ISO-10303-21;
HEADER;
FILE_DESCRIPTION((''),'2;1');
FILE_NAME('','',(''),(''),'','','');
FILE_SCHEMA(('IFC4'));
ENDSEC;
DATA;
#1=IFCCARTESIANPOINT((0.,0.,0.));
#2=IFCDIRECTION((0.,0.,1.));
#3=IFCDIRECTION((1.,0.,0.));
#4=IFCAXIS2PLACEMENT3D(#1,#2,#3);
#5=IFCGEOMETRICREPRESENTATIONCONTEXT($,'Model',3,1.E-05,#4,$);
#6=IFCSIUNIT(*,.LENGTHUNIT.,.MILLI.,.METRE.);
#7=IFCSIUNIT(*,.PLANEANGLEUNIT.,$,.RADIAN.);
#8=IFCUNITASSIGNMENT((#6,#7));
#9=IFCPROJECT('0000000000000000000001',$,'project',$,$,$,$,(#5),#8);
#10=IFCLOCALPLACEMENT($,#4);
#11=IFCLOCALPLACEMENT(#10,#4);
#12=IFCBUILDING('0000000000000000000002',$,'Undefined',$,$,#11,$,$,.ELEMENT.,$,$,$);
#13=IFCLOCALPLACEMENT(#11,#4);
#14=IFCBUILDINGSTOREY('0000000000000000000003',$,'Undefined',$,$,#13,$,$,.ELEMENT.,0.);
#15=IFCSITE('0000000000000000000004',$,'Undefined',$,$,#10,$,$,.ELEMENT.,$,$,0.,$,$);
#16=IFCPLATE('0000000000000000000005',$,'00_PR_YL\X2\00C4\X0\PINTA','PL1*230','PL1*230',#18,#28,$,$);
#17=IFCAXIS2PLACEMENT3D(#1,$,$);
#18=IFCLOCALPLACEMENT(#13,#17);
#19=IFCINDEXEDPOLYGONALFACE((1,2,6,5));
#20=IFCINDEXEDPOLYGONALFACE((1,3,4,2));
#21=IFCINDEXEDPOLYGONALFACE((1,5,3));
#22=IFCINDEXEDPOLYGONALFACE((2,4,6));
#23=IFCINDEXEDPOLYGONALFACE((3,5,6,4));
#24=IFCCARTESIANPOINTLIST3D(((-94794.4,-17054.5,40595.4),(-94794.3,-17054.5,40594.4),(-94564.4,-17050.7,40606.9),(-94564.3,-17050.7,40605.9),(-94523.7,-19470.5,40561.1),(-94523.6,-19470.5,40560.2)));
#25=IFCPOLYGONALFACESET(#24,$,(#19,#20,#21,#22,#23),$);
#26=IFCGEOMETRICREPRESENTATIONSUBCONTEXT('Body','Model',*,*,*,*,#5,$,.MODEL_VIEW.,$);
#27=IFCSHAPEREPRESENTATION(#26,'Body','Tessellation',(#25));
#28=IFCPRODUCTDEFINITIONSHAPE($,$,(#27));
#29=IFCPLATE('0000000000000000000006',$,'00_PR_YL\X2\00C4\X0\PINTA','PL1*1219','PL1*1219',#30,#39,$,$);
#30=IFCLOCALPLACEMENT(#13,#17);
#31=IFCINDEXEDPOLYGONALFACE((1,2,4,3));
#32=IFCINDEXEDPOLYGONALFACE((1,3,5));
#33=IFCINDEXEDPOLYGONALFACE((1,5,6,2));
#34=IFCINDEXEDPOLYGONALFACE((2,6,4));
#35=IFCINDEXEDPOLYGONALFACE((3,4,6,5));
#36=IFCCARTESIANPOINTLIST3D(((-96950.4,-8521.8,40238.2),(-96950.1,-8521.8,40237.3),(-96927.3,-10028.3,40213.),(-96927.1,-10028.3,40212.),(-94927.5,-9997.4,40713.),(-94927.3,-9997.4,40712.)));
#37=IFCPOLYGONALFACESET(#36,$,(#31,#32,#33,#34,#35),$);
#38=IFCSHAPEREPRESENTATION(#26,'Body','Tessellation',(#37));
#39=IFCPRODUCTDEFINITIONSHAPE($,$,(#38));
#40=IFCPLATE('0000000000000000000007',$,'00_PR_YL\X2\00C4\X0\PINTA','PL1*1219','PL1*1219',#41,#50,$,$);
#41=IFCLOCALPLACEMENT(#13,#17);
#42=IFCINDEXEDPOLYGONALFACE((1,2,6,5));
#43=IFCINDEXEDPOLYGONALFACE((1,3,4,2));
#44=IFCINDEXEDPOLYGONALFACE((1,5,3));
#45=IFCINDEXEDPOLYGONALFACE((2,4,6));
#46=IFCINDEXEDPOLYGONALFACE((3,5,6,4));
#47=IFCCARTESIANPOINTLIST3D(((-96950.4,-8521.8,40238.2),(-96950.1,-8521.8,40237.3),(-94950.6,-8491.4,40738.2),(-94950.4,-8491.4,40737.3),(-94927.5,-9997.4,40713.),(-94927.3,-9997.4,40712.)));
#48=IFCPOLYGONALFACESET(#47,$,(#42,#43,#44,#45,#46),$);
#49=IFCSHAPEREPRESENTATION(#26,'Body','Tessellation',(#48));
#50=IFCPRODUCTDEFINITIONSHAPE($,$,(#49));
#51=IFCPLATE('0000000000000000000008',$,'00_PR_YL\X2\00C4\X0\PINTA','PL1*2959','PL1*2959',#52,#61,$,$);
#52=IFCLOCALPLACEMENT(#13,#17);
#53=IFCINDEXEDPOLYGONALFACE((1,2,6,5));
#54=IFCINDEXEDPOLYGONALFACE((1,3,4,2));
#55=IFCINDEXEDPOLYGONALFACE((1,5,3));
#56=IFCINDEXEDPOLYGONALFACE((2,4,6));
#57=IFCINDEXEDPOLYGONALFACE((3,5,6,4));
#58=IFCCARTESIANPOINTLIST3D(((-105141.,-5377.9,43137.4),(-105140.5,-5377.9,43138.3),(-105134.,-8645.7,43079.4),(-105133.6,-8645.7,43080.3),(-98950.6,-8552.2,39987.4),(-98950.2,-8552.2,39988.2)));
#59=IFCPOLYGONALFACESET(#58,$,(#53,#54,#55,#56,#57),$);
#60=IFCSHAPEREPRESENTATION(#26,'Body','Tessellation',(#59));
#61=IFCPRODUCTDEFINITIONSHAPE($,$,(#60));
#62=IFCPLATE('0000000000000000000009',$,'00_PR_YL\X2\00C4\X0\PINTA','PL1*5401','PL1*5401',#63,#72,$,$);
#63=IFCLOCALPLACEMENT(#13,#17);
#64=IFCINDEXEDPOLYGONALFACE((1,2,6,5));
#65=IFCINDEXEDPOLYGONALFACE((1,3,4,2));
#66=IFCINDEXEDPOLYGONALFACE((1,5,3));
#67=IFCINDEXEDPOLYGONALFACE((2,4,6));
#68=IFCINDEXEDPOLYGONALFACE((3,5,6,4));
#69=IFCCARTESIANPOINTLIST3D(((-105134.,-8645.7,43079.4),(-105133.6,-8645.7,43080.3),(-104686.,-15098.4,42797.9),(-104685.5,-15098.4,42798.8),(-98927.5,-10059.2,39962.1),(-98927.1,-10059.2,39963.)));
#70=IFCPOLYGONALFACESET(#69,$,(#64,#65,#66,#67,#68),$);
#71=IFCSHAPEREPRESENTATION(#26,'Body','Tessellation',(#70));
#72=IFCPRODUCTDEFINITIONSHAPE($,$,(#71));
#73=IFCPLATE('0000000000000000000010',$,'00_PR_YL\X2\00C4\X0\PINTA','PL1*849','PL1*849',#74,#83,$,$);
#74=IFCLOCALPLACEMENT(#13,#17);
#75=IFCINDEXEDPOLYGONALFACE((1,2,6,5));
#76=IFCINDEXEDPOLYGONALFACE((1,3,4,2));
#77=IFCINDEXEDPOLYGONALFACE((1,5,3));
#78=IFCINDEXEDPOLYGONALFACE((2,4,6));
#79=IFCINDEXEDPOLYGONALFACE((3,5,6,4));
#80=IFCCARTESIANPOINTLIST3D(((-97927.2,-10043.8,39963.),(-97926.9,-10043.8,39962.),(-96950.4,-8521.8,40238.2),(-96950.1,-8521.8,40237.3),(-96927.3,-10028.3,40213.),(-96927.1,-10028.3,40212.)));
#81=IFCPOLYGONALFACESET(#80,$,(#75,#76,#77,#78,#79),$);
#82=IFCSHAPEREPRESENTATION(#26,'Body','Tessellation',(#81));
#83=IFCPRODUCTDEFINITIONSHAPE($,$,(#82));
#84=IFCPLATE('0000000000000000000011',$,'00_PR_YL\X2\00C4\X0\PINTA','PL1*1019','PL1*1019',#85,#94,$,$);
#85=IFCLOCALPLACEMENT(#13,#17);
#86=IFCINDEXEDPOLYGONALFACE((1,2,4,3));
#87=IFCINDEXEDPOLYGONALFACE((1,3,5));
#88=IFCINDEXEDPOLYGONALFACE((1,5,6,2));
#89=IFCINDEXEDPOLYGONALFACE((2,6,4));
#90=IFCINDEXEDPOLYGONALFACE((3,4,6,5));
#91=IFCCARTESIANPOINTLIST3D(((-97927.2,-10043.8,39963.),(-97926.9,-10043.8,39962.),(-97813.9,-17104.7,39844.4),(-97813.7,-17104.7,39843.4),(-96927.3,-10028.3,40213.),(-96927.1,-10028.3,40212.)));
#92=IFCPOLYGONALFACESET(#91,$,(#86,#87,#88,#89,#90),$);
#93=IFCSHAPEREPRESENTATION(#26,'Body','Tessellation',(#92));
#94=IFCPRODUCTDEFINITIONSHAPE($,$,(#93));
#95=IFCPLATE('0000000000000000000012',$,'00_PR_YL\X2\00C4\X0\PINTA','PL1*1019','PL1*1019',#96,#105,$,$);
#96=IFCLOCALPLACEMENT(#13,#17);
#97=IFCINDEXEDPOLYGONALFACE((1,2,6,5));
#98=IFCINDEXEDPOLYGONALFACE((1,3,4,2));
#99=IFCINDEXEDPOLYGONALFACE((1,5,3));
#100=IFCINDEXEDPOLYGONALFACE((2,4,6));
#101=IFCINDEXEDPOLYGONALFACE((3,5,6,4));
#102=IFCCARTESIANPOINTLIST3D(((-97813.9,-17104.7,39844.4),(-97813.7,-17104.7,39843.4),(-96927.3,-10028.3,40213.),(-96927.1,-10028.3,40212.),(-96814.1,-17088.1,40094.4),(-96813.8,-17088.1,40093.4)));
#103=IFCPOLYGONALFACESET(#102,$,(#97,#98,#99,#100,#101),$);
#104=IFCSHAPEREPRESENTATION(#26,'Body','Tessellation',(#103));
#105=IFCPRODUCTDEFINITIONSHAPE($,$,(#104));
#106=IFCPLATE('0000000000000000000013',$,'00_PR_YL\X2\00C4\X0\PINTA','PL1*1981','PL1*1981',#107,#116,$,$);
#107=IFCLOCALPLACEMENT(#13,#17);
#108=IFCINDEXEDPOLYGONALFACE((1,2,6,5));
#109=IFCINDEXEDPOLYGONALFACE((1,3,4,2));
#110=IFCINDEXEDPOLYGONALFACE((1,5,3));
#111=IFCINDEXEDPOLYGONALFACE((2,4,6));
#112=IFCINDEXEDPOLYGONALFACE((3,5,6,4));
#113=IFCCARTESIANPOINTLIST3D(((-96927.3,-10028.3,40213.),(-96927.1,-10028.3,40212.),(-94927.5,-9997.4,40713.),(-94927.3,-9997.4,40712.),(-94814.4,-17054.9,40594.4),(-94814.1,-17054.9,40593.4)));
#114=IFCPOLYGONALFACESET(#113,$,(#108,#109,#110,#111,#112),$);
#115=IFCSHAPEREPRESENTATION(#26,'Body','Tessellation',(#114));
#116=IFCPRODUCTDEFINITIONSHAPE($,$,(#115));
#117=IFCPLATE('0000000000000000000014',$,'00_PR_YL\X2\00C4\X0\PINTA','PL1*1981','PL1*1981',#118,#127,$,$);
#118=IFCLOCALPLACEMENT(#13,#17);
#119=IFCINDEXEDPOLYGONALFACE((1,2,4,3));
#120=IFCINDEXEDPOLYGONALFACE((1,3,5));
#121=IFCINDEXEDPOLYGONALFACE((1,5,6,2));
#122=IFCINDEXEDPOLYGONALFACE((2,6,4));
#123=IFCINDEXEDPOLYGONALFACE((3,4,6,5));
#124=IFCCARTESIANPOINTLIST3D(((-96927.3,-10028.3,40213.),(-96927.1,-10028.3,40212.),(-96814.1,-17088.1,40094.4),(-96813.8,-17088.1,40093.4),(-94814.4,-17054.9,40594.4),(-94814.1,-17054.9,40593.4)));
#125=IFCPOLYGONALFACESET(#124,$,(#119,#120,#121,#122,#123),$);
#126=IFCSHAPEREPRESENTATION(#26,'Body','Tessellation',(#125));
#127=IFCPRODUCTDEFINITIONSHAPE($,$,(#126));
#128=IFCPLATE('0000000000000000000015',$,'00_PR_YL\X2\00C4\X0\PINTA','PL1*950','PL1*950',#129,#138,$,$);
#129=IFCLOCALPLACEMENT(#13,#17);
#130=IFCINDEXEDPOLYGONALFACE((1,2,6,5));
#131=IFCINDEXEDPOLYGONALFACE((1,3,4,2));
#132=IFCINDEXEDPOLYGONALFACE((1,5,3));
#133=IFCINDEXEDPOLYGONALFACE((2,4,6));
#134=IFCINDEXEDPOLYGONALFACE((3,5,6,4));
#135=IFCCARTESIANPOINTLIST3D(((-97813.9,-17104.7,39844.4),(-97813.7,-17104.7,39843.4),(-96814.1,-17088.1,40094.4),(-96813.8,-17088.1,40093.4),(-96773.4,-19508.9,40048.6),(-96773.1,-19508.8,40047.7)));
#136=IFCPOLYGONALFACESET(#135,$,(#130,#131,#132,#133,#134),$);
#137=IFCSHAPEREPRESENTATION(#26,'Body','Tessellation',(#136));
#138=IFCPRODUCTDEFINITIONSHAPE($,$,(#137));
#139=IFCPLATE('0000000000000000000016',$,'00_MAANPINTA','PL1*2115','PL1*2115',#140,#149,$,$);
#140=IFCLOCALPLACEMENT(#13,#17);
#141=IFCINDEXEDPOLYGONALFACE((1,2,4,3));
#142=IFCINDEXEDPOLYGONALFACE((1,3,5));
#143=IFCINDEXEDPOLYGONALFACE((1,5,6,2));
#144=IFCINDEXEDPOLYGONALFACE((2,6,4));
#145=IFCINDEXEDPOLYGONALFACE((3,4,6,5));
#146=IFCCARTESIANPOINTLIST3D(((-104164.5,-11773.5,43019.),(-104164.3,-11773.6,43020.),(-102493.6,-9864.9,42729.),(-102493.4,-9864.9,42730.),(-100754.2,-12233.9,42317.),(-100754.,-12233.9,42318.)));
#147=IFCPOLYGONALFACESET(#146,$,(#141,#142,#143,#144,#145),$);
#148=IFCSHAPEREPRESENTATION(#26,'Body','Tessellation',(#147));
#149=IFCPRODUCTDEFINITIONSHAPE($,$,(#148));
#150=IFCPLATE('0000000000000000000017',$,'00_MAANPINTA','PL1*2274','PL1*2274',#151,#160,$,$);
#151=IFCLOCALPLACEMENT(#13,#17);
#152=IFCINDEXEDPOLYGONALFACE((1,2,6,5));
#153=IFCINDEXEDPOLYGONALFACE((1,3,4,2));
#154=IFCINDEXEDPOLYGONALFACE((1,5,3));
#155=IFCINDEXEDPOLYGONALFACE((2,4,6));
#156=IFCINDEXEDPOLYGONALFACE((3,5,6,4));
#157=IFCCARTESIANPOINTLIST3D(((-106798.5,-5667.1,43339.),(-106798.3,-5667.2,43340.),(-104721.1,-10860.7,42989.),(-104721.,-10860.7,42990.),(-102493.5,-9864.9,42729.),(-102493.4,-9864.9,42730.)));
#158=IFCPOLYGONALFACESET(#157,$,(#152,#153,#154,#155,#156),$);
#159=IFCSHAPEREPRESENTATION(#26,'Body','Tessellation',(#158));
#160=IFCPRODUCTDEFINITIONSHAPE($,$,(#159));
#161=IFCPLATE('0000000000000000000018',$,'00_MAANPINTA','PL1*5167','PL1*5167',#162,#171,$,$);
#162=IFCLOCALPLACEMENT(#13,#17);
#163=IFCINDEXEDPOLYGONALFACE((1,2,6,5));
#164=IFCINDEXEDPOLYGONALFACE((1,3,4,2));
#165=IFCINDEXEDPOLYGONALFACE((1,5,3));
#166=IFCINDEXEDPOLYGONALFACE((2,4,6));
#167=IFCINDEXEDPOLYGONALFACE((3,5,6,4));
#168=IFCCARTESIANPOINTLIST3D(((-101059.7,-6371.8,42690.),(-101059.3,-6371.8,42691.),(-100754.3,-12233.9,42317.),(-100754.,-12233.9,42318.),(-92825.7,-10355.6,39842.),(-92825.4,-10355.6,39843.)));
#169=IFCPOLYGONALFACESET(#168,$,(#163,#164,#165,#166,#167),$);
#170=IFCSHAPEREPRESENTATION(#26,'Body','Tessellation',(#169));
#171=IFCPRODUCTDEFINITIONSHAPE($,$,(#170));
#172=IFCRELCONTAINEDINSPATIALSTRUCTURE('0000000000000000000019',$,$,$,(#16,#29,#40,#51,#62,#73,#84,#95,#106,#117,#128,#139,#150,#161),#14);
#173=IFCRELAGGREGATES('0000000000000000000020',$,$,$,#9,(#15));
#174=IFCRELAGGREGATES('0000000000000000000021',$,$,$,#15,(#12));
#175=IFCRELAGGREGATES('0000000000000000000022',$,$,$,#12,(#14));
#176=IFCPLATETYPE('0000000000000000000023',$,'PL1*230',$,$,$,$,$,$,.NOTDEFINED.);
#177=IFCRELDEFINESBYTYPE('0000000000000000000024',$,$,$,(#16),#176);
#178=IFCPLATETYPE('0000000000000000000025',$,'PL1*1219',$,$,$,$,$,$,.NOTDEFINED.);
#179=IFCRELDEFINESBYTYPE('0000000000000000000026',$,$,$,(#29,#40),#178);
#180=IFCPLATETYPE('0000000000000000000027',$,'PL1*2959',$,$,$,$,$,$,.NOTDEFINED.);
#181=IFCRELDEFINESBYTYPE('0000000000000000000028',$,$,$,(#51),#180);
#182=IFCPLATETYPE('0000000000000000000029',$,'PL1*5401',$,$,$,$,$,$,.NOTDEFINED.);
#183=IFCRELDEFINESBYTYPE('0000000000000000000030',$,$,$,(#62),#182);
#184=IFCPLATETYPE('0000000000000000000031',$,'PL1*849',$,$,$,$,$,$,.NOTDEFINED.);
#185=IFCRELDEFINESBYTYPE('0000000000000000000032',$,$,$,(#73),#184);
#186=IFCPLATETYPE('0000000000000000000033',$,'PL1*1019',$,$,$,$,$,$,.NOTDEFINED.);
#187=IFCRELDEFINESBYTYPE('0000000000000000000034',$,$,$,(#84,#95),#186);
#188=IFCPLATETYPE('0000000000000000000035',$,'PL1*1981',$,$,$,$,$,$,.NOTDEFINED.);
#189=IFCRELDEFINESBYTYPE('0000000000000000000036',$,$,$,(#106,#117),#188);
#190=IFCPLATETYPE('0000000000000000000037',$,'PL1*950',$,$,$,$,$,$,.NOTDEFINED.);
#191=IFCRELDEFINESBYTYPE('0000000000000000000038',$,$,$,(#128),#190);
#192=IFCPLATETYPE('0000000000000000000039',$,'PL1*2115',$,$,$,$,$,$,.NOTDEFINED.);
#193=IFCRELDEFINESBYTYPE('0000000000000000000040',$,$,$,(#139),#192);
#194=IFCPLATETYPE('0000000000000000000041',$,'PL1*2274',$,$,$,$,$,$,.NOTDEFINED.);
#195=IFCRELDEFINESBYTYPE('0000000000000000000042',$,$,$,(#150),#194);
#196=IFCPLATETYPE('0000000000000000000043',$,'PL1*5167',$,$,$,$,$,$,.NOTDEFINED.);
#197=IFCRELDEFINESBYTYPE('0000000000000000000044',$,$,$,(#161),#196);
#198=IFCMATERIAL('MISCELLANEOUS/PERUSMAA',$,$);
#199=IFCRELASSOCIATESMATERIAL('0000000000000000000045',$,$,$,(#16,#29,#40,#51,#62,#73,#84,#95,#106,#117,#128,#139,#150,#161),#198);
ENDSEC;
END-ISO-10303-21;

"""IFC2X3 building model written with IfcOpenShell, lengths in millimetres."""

from ifc_helpers import new_model, si_unit, frame, origin_with_axes, place, context, subcontext, project, spatial, polyline, outline, extrude, material, type_object, element, save


model = new_model("IFC2X3")

# Units and contexts
model_context = context("Model", 3, precision=1e-05, world=origin_with_axes())
body_context = subcontext(model_context, "Body", "Model", "MODEL_VIEW")
ifc_project = project(units=[si_unit("LENGTHUNIT", "METRE", prefix="MILLI"), si_unit("PLANEANGLEUNIT", "RADIAN")], contexts=[model_context])

# Site, building, storey
site_placement = place(None, origin_with_axes())
site = spatial("IfcSite", under=ifc_project, at=site_placement, Name="Undefined", CompositionType="ELEMENT", RefElevation=0.0)
building_placement = place(site_placement, origin_with_axes())
building = spatial("IfcBuilding", under=site, at=building_placement, Name="Undefined", CompositionType="ELEMENT")
storey_placement = place(building_placement, origin_with_axes())
storey = spatial("IfcBuildingStorey", under=building, at=storey_placement, Name="Undefined", CompositionType="ELEMENT", Elevation=0.0)

# Plates
ifc_material = material(Name="MISCELLANEOUS/PERUSMAA")
plate_type_1 = type_object("IfcPlateType", Name="PL1*230", PredefinedType="NOTDEFINED")
plate_1_placement = place(storey_placement, frame((-94794.3, -17054.5, 40594.9), z_axis=(0.049608, 0.019701, -0.998574), x_axis=(0.998614, 0.016601, 0.049937)))
element("IfcPlate", 1, at=plate_1_placement, inside=storey, type_object=plate_type_1, material=ifc_material, Name="00_PR_YLÄPINTA", Description="PL1*230", ObjectType="PL1*230", context=body_context, shape_type="SweptSolid", body=[
    extrude(outline(polyline([(0.0, 0.0), (230.3, 0.0), (228.5, 2420.6), (0.0, 0.0)])), frame((0.0, 0.0, -0.5), z_axis=(0.0, 0.0, 1.0), x_axis=(1.0, 0.0, 0.0)), (0.0, 0.0, 1.0), 1.0),
])
plate_type_2 = type_object("IfcPlateType", Name="PL1*1219", PredefinedType="NOTDEFINED")
plate_2_placement = place(storey_placement, frame((-94927.4, -9997.4, 40712.5), z_axis=(0.242224, 0.019968, -0.970015), x_axis=(-0.970027, -0.014987, -0.242536)))
element("IfcPlate", 2, at=plate_2_placement, inside=storey, type_object=plate_type_2, material=ifc_material, Name="00_PR_YLÄPINTA", Description="PL1*1219", ObjectType="PL1*1219", context=body_context, shape_type="SweptSolid", body=[
    extrude(outline(polyline([(0.0, 0.0), (2061.6, 0.0), (2055.2, 1506.9), (0.0, 0.0)])), frame((0.0, 0.0, -0.5), z_axis=(0.0, 0.0, 1.0), x_axis=(1.0, 0.0, 0.0)), (0.0, 0.0, 1.0), 1.0),
])
plate_3_placement = place(storey_placement, frame((-94927.4, -9997.4, 40712.5), z_axis=(0.242228, 0.019974, -0.970014), x_axis=(-0.793739, 0.579031, -0.186286)))
element("IfcPlate", 3, at=plate_3_placement, inside=storey, type_object=plate_type_2, material=ifc_material, Name="00_PR_YLÄPINTA", Description="PL1*1219", ObjectType="PL1*1219", context=body_context, shape_type="SweptSolid", body=[
    extrude(outline(polyline([(0.0, 0.0), (2548.5, 0.0), (885.7, 1218.6), (0.0, 0.0)])), frame((0.0, 0.0, -0.5), z_axis=(0.0, 0.0, 1.0), x_axis=(1.0, 0.0, 0.0)), (0.0, 0.0, 1.0), 1.0),
])
plate_type_3 = type_object("IfcPlateType", Name="PL1*2959", PredefinedType="NOTDEFINED")
plate_4_placement = place(storey_placement, frame((-98950.4, -8552.2, 39987.8), z_axis=(-0.447385, 0.014925, -0.894217), x_axis=(-0.894325, -0.013529, 0.447214)))
element("IfcPlate", 4, at=plate_4_placement, inside=storey, type_object=plate_type_3, material=ifc_material, Name="00_PR_YLÄPINTA", Description="PL1*2959", ObjectType="PL1*2959", context=body_context, shape_type="SweptSolid", body=[
    extrude(outline(polyline([(0.0, 0.0), (6914.0, 0.0), (6902.0, 3268.3), (0.0, 0.0)])), frame((0.0, 0.0, -0.5), z_axis=(0.0, 0.0, 1.0), x_axis=(1.0, 0.0, 0.0)), (0.0, 0.0, 1.0), 1.0),
])
plate_type_4 = type_object("IfcPlateType", Name="PL1*5401", PredefinedType="NOTDEFINED")
plate_5_placement = place(storey_placement, frame((-98927.3, -10059.2, 39962.5), z_axis=(-0.44737, 0.007957, -0.894314), x_axis=(-0.705648, -0.6175, 0.347498)))
element("IfcPlate", 5, at=plate_5_placement, inside=storey, type_object=plate_type_4, material=ifc_material, Name="00_PR_YLÄPINTA", Description="PL1*5401", ObjectType="PL1*5401", context=body_context, shape_type="SweptSolid", body=[
    extrude(outline(polyline([(0.0, 0.0), (8160.5, 0.0), (4590.0, 5400.7), (0.0, 0.0)])), frame((0.0, 0.0, -0.5), z_axis=(0.0, 0.0, 1.0), x_axis=(1.0, 0.0, 0.0)), (0.0, 0.0, 1.0), 1.0),
])
plate_type_5 = type_object("IfcPlateType", Name="PL1*849", PredefinedType="NOTDEFINED")
plate_6_placement = place(storey_placement, frame((-97927.1, -10043.8, 39962.5), z_axis=(0.242224, 0.019968, -0.970015), x_axis=(0.533965, 0.83201, 0.150465)))
element("IfcPlate", 6, at=plate_6_placement, inside=storey, type_object=plate_type_5, material=ifc_material, Name="00_PR_YLÄPINTA", Description="PL1*849", ObjectType="PL1*849", context=body_context, shape_type="SweptSolid", body=[
    extrude(outline(polyline([(0.0, 0.0), (1829.3, 0.0), (584.4, 849.1), (0.0, 0.0)])), frame((0.0, 0.0, -0.5), z_axis=(0.0, 0.0, 1.0), x_axis=(1.0, 0.0, 0.0)), (0.0, 0.0, 1.0), 1.0),
])
plate_type_6 = type_object("IfcPlateType", Name="PL1*1019", PredefinedType="NOTDEFINED")
plate_7_placement = place(storey_placement, frame((-96927.2, -10028.3, 40212.5), z_axis=(0.24222, 0.020181, -0.970011), x_axis=(-0.124159, -0.990919, -0.05162)))
element("IfcPlate", 7, at=plate_7_placement, inside=storey, type_object=plate_type_6, material=ifc_material, Name="00_PR_YLÄPINTA", Description="PL1*1019", ObjectType="PL1*1019", context=body_context, shape_type="SweptSolid", body=[
    extrude(outline(polyline([(0.0, 0.0), (7141.2, 0.0), (152.4, 1019.5), (0.0, 0.0)])), frame((0.0, 0.0, -0.5), z_axis=(0.0, 0.0, 1.0), x_axis=(1.0, 0.0, 0.0)), (0.0, 0.0, 1.0), 1.0),
])
plate_8_placement = place(storey_placement, frame((-97813.8, -17104.7, 39843.9), z_axis=(0.242202, 0.020184, -0.970016), x_axis=(0.124159, 0.990919, 0.05162)))
element("IfcPlate", 8, at=plate_8_placement, inside=storey, type_object=plate_type_6, material=ifc_material, Name="00_PR_YLÄPINTA", Description="PL1*1019", ObjectType="PL1*1019", context=body_context, shape_type="SweptSolid", body=[
    extrude(outline(polyline([(0.0, 0.0), (7141.2, 0.0), (153.5, 1019.3), (0.0, 0.0)])), frame((0.0, 0.0, -0.5), z_axis=(0.0, 0.0, 1.0), x_axis=(1.0, 0.0, 0.0)), (0.0, 0.0, 1.0), 1.0),
])
plate_type_7 = type_object("IfcPlateType", Name="PL1*1981", PredefinedType="NOTDEFINED")
plate_9_placement = place(storey_placement, frame((-94814.2, -17054.9, 40593.9), z_axis=(0.24222, 0.020189, -0.970011), x_axis=(-0.287583, 0.956348, -0.051907)))
element("IfcPlate", 9, at=plate_9_placement, inside=storey, type_object=plate_type_7, material=ifc_material, Name="00_PR_YLÄPINTA", Description="PL1*1981", ObjectType="PL1*1981", context=body_context, shape_type="SweptSolid", body=[
    extrude(outline(polyline([(0.0, 0.0), (7347.2, 0.0), (6775.7, 1980.8), (0.0, 0.0)])), frame((0.0, 0.0, -0.5), z_axis=(0.0, 0.0, 1.0), x_axis=(1.0, 0.0, 0.0)), (0.0, 0.0, 1.0), 1.0),
])
plate_10_placement = place(storey_placement, frame((-96814.0, -17088.1, 40093.9), z_axis=(0.242202, 0.020184, -0.970016), x_axis=(-0.016032, 0.99973, 0.016799)))
element("IfcPlate", 10, at=plate_10_placement, inside=storey, type_object=plate_type_7, material=ifc_material, Name="00_PR_YLÄPINTA", Description="PL1*1981", ObjectType="PL1*1981", context=body_context, shape_type="SweptSolid", body=[
    extrude(outline(polyline([(0.0, 0.0), (7061.7, 0.0), (9.6, 2061.5), (0.0, 0.0)])), frame((0.0, 0.0, -0.5), z_axis=(0.0, 0.0, 1.0), x_axis=(1.0, 0.0, 0.0)), (0.0, 0.0, 1.0), 1.0),
])
plate_type_8 = type_object("IfcPlateType", Name="PL1*950", PredefinedType="NOTDEFINED")
plate_11_placement = place(storey_placement, frame((-97813.8, -17104.7, 39843.9), z_axis=(0.242156, 0.022394, -0.969979), x_axis=(0.970009, 0.016125, 0.242536)))
element("IfcPlate", 11, at=plate_11_placement, inside=storey, type_object=plate_type_8, material=ifc_material, Name="00_PR_YLÄPINTA", Description="PL1*950", ObjectType="PL1*950", context=body_context, shape_type="SweptSolid", body=[
    extrude(outline(polyline([(0.0, 0.0), (1030.8, 0.0), (1020.2, 2421.5), (0.0, 0.0)])), frame((0.0, 0.0, -0.5), z_axis=(0.0, 0.0, 1.0), x_axis=(1.0, 0.0, 0.0)), (0.0, 0.0, 1.0), 1.0),
])
plate_type_9 = type_object("IfcPlateType", Name="PL1*2115", PredefinedType="NOTDEFINED")
plate_12_placement = place(storey_placement, frame((-102493.5, -9864.9, 42729.5), z_axis=(-0.198345, 0.024771, -0.979819), x_axis=(0.586112, -0.798248, -0.138827)))
element("IfcPlate", 12, at=plate_12_placement, inside=storey, type_object=plate_type_9, material=ifc_material, Name="00_MAANPINTA", Description="PL1*2115", ObjectType="PL1*2115", context=body_context, shape_type="SweptSolid", body=[
    extrude(outline(polyline([(0.0, 0.0), (2967.7, 0.0), (503.9, 2503.0), (0.0, 0.0)])), frame((0.0, 0.0, -0.5), z_axis=(0.0, 0.0, 1.0), x_axis=(1.0, 0.0, 0.0)), (0.0, 0.0, 1.0), 1.0),
])
plate_type_10 = type_object("IfcPlateType", Name="PL1*2274", PredefinedType="NOTDEFINED")
plate_13_placement = place(storey_placement, frame((-102493.4, -9864.9, 42729.5), z_axis=(-0.123595, 0.017428, -0.99218), x_axis=(-0.907803, -0.405791, 0.105957)))
element("IfcPlate", 13, at=plate_13_placement, inside=storey, type_object=plate_type_10, material=ifc_material, Name="00_MAANPINTA", Description="PL1*2274", ObjectType="PL1*2274", context=body_context, shape_type="SweptSolid", body=[
    extrude(outline(polyline([(0.0, 0.0), (2453.8, 0.0), (2269.3, 5601.5), (0.0, 0.0)])), frame((0.0, 0.0, -0.5), z_axis=(0.0, 0.0, 1.0), x_axis=(1.0, 0.0, 0.0)), (0.0, 0.0, 1.0), 1.0),
])
plate_type_11 = type_object("IfcPlateType", Name="PL1*5167", PredefinedType="NOTDEFINED")
plate_14_placement = place(storey_placement, frame((-100754.1, -12233.9, 42317.5), z_axis=(-0.307272, 0.044478, -0.950582), x_axis=(-0.051919, 0.996636, 0.063415)))
element("IfcPlate", 14, at=plate_14_placement, inside=storey, type_object=plate_type_11, material=ifc_material, Name="00_MAANPINTA", Description="PL1*5167", ObjectType="PL1*5167", context=body_context, shape_type="SweptSolid", body=[
    extrude(outline(polyline([(0.0, 0.0), (5881.9, 0.0), (1303.3, 8415.3), (0.0, 0.0)])), frame((0.0, 0.0, -0.5), z_axis=(0.0, 0.0, 1.0), x_axis=(1.0, 0.0, 0.0)), (0.0, 0.0, 1.0), 1.0),
])

save(model, "model.ifc")
